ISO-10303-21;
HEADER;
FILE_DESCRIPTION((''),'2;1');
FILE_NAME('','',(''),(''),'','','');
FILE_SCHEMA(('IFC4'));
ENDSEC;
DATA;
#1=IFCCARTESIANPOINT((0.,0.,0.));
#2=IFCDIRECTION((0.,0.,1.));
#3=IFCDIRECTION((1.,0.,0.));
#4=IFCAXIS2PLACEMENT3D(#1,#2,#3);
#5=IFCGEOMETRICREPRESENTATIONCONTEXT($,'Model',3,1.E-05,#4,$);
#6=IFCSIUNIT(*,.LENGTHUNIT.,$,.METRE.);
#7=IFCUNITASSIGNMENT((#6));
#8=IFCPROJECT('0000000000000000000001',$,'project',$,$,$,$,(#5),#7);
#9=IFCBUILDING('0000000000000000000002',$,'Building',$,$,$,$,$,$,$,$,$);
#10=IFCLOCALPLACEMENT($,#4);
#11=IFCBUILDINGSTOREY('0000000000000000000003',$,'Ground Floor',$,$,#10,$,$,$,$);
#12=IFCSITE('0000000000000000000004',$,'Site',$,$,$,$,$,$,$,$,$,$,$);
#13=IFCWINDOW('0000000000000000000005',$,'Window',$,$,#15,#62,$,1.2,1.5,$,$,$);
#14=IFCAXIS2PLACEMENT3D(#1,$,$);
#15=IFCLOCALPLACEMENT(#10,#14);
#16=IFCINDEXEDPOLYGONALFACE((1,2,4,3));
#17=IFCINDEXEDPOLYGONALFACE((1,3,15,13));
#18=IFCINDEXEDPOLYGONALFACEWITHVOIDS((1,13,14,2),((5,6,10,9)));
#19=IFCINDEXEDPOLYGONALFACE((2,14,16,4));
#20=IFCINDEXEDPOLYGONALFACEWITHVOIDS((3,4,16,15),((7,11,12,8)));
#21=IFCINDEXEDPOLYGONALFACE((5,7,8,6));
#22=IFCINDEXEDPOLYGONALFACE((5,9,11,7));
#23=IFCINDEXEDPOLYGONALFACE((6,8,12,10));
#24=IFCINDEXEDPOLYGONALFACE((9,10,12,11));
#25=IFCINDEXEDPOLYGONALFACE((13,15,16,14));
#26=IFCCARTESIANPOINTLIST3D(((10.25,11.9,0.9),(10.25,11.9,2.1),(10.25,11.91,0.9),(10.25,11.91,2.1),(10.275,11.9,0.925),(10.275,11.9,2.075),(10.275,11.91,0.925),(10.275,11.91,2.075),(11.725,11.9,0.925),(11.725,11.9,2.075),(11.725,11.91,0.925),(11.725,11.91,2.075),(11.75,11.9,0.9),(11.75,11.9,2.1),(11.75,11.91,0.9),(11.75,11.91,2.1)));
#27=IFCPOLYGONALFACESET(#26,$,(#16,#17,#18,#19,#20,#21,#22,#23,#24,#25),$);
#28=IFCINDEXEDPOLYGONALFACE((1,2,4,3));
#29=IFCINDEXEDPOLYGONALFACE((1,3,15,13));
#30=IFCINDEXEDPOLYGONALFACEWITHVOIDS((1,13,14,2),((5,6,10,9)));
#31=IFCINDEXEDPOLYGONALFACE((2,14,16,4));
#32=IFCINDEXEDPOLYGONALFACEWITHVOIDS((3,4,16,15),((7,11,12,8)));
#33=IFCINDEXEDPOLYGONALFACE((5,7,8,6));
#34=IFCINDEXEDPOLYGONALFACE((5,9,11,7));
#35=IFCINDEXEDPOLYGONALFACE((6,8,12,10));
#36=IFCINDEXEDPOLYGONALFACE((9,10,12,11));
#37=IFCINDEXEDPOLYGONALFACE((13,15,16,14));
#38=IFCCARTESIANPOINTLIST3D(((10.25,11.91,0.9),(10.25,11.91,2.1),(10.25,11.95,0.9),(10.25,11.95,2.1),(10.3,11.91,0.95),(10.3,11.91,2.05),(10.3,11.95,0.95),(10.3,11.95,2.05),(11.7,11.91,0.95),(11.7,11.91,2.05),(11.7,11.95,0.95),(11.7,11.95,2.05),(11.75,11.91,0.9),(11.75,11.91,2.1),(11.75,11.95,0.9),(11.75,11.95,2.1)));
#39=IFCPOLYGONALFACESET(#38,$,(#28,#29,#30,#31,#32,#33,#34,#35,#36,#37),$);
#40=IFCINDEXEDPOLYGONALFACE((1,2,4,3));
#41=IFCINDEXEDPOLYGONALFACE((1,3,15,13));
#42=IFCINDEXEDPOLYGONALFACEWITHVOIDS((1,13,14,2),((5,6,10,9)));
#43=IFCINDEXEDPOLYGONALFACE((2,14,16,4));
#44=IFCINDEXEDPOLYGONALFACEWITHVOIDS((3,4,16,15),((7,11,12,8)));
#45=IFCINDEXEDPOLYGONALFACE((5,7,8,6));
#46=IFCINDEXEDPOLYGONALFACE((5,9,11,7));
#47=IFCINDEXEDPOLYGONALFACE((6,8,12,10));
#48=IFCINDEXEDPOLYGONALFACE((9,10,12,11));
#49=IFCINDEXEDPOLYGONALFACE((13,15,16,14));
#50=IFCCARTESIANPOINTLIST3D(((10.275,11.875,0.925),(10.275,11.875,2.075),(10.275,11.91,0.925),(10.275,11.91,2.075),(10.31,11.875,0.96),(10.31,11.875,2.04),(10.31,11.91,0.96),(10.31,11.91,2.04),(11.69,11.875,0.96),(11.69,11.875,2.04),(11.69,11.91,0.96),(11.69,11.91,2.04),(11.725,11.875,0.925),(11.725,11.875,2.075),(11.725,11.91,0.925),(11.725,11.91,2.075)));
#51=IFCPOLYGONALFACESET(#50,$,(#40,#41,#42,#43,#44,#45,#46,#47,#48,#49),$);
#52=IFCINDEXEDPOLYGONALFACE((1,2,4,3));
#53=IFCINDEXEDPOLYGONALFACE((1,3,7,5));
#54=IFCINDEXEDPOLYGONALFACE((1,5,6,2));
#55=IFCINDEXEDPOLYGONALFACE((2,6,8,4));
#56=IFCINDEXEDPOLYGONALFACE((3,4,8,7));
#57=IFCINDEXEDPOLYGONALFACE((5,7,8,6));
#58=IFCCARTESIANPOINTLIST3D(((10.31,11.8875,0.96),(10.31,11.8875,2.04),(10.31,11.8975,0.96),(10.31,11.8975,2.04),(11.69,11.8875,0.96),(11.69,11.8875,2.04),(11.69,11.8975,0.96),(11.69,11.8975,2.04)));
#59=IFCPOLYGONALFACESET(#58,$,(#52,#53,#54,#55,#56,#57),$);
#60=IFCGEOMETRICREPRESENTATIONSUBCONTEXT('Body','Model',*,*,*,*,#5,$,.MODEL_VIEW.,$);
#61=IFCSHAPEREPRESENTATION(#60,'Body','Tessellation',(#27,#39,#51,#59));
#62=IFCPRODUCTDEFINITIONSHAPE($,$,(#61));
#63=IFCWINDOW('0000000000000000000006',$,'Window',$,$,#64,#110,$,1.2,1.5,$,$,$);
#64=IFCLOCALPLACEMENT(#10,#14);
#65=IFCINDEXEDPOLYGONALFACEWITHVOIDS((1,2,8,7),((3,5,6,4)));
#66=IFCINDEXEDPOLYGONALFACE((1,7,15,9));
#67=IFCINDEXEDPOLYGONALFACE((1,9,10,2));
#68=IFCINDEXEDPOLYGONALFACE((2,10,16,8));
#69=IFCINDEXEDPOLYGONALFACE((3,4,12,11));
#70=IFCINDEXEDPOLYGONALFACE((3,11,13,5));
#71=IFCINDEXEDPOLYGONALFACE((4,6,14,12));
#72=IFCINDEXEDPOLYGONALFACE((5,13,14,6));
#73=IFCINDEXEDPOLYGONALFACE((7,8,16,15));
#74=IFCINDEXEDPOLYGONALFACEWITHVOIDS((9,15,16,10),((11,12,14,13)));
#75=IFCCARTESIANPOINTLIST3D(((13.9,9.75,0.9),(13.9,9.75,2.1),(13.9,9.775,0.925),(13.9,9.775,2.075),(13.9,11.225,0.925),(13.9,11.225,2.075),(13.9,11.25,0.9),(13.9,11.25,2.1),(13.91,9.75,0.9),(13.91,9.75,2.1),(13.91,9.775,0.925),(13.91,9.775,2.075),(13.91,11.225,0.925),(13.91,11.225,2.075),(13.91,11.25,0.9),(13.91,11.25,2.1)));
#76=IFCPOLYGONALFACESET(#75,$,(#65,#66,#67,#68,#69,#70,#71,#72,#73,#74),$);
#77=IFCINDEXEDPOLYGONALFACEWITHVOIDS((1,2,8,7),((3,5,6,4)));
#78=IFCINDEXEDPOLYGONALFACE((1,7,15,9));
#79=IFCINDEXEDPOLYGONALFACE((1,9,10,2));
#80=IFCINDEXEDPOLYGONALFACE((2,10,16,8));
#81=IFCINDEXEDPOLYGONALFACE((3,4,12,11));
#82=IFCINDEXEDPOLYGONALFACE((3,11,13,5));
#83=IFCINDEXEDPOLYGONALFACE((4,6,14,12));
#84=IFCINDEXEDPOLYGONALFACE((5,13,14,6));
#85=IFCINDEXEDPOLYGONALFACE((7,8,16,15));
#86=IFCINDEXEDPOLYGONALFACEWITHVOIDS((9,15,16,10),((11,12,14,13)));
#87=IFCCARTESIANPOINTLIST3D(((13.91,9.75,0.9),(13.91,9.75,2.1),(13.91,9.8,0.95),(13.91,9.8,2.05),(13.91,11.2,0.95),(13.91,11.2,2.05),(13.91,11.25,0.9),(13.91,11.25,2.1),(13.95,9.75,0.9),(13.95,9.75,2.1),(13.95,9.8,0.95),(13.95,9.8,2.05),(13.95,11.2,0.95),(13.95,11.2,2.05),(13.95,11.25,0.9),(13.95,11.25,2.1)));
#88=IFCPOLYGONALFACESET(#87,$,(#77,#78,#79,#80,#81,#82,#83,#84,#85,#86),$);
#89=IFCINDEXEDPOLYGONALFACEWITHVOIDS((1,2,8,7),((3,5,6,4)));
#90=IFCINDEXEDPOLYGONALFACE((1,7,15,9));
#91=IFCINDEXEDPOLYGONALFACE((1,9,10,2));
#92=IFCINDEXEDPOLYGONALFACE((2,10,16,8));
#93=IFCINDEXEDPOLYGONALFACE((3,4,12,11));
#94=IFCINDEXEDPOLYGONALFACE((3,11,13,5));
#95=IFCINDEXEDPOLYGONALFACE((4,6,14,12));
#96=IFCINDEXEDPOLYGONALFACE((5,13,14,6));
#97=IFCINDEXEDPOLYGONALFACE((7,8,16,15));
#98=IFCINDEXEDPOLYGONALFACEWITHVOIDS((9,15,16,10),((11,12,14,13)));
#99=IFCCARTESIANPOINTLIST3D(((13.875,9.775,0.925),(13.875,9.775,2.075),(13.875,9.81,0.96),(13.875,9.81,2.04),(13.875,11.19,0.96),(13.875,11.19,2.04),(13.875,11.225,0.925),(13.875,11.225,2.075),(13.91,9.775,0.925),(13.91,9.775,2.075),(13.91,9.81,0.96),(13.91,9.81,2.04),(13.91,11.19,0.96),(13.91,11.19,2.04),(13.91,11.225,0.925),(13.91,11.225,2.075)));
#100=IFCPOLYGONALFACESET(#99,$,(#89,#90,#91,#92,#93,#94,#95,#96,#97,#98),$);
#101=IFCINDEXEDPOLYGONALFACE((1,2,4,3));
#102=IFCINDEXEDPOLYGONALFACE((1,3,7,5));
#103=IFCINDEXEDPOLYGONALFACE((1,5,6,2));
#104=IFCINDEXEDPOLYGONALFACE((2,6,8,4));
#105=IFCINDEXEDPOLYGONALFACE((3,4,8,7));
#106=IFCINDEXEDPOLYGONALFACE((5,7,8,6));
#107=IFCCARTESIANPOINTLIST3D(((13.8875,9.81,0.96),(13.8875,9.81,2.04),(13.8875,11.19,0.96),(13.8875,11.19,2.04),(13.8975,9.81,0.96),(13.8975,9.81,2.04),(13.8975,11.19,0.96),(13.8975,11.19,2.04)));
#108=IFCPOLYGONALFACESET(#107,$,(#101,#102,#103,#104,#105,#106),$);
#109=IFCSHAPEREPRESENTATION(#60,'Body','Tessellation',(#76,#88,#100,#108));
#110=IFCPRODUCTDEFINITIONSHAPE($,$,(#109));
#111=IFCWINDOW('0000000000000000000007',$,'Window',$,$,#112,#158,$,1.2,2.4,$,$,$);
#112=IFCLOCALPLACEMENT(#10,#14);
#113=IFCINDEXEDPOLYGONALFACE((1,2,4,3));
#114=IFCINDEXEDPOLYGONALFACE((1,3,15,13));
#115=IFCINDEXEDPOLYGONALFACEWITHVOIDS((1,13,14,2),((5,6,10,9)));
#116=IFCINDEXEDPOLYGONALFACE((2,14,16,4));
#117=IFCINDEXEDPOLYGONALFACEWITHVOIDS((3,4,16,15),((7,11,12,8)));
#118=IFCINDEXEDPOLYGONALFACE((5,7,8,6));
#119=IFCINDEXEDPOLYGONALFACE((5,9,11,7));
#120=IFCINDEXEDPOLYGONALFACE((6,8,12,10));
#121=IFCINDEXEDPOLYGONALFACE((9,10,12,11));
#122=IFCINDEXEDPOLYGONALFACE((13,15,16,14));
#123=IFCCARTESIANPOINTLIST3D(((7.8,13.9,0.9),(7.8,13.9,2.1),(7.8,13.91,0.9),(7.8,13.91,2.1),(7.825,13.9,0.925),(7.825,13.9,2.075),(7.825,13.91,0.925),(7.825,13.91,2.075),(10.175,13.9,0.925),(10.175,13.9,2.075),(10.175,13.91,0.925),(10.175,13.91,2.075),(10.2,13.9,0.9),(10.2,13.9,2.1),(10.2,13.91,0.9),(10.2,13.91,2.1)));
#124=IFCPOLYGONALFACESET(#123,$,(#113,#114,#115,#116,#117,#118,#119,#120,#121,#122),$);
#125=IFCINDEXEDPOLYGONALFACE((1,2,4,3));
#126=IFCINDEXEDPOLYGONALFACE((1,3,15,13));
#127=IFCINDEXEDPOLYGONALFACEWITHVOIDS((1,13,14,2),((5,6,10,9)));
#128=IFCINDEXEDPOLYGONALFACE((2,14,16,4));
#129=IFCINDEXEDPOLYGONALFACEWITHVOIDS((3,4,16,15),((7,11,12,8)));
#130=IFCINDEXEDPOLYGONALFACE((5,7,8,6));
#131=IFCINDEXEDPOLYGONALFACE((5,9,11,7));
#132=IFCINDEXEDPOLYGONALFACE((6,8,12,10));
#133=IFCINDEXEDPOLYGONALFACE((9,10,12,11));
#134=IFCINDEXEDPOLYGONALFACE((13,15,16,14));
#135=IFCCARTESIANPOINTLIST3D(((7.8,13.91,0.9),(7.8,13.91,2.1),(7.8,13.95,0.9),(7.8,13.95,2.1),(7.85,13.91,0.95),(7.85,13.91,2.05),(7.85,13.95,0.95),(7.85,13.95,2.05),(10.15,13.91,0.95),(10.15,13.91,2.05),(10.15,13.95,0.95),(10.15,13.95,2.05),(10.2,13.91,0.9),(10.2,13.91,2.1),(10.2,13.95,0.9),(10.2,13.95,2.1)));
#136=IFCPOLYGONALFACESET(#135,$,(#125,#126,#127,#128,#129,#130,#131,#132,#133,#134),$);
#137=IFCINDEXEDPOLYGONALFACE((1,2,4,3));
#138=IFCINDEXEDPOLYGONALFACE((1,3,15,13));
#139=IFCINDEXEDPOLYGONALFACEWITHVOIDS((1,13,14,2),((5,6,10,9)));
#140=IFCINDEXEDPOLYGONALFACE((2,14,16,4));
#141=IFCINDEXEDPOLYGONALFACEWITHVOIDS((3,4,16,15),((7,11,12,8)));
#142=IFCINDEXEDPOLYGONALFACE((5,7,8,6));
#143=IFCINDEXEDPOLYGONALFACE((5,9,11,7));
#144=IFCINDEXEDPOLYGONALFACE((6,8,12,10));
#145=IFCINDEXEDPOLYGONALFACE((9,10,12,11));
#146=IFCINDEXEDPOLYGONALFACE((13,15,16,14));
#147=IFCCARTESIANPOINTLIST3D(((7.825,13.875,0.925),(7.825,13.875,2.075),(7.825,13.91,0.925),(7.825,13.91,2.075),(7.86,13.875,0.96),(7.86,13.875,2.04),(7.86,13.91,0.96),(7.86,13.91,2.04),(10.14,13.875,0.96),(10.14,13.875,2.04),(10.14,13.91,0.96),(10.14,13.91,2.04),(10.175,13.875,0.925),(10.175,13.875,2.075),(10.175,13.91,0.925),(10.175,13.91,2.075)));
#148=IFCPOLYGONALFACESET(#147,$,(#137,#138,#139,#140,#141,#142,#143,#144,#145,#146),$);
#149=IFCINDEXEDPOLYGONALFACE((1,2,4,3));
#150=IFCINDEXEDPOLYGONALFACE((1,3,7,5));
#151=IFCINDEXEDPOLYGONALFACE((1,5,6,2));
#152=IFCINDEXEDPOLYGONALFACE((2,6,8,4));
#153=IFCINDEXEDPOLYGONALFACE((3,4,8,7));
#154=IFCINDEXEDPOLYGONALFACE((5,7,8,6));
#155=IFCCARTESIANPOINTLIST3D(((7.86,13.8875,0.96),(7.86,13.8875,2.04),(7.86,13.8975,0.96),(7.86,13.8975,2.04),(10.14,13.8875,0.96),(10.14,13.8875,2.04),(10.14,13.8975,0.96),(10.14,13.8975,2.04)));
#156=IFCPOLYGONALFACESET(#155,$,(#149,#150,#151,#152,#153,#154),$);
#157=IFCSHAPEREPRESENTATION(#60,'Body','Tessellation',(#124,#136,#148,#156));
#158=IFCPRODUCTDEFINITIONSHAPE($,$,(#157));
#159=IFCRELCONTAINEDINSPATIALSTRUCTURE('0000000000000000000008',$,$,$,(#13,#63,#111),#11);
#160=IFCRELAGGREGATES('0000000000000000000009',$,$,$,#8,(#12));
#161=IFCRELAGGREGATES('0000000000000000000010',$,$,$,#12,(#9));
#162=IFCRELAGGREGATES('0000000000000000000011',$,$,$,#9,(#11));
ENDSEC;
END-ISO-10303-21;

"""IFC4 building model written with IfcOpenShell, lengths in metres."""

from ifc_helpers import new_model, si_unit, frame, origin_with_axes, place, context, subcontext, project, spatial, line, indexed_curve, outline, extrude, element, save


model = new_model("IFC4")

# Units and contexts
model_context = context("Model", 3, precision=1e-05, world=origin_with_axes())
body_context = subcontext(model_context, "Body", "Model", "MODEL_VIEW")
ifc_project = project(units=[si_unit("LENGTHUNIT", "METRE")], contexts=[model_context])

# Site, building, storey
site = spatial("IfcSite", under=ifc_project, Name="Site")
building = spatial("IfcBuilding", under=site, Name="Building")
storey_placement = place(None, origin_with_axes())
storey = spatial("IfcBuildingStorey", under=building, at=storey_placement, Name="Ground Floor")

# Windows
for number, where, z_axis, x_axis, name in (
    (1, (11.75, 12.0, 0.9), (0.0, 0.0, 1.0), (-1.0, 0.0, 0.0), "Window"),
    (2, (14.0, 9.75, 0.9), (0.0, 0.0, 1.0), (0.0, 1.0, 0.0), "Window"),
):
    element("IfcWindow", number, at=place(storey_placement, frame(where, z_axis=z_axis, x_axis=x_axis)), inside=storey, Name=name, OverallHeight=1.2, OverallWidth=1.5, context=body_context, shape_type="SweptSolid", body=[
        extrude(outline(indexed_curve([(0.0, 0.0), (1.5, 0.0), (1.5, 1.2), (0.0, 1.2)], segments=[line(1, 2, 3, 4, 1)]), holes=[indexed_curve([(0.025, 0.025), (1.475, 0.025), (1.475, 1.175), (0.025, 1.175)], segments=[line(1, 2, 3, 4, 1)])]), frame((0.0, 0.09, 0.0), z_axis=(0.0, -1.0, 0.0), x_axis=(1.0, 0.0, 0.0)), (0.0, 0.0, -1.0), 0.01),
        extrude(outline(indexed_curve([(0.0, 0.0), (1.5, 0.0), (1.5, 1.2), (0.0, 1.2)], segments=[line(1, 2, 3, 4, 1)]), holes=[indexed_curve([(0.05, 0.05), (1.45, 0.05), (1.45, 1.15), (0.05, 1.15)], segments=[line(1, 2, 3, 4, 1)])]), frame((0.0, 0.05, 0.0), z_axis=(0.0, -1.0, 0.0), x_axis=(1.0, 0.0, 0.0)), (0.0, 0.0, -1.0), 0.04),
        extrude(outline(indexed_curve([(0.0, 0.0), (1.45, 0.0), (1.45, 1.15), (0.0, 1.15)], segments=[line(1, 2, 3, 4, 1)]), holes=[indexed_curve([(0.035, 0.035), (1.415, 0.035), (1.415, 1.115), (0.035, 1.115)], segments=[line(1, 2, 3, 4, 1)])]), frame((0.025, 0.09, 0.025), z_axis=(0.0, -1.0, 0.0), x_axis=(1.0, 0.0, 0.0)), (0.0, 0.0, -1.0), 0.035),
        extrude(outline(indexed_curve([(0.035, 0.035), (1.415, 0.035), (1.415, 1.115), (0.035, 1.115)], segments=[line(1, 2, 3, 4, 1)])), frame((0.025, 0.1025, 0.025), z_axis=(0.0, -1.0, 0.0), x_axis=(1.0, 0.0, 0.0)), (0.0, 0.0, -1.0), 0.01),
    ])
window_1_placement = place(storey_placement, frame((10.2, 14.0, 0.9), z_axis=(0.0, 0.0, 1.0), x_axis=(-1.0, 0.0, 0.0)))
element("IfcWindow", 3, at=window_1_placement, inside=storey, Name="Window", OverallHeight=1.2, OverallWidth=2.4, context=body_context, shape_type="SweptSolid", body=[
    extrude(outline(indexed_curve([(0.0, 0.0), (2.4, 0.0), (2.4, 1.2), (0.0, 1.2)], segments=[line(1, 2, 3, 4, 1)]), holes=[indexed_curve([(0.025, 0.025), (2.375, 0.025), (2.375, 1.175), (0.025, 1.175)], segments=[line(1, 2, 3, 4, 1)])]), frame((0.0, 0.09, 0.0), z_axis=(0.0, -1.0, 0.0), x_axis=(1.0, 0.0, 0.0)), (0.0, 0.0, -1.0), 0.01),
    extrude(outline(indexed_curve([(0.0, 0.0), (2.4, 0.0), (2.4, 1.2), (0.0, 1.2)], segments=[line(1, 2, 3, 4, 1)]), holes=[indexed_curve([(0.05, 0.05), (2.35, 0.05), (2.35, 1.15), (0.05, 1.15)], segments=[line(1, 2, 3, 4, 1)])]), frame((0.0, 0.05, 0.0), z_axis=(0.0, -1.0, 0.0), x_axis=(1.0, 0.0, 0.0)), (0.0, 0.0, -1.0), 0.04),
    extrude(outline(indexed_curve([(0.0, 0.0), (2.35, 0.0), (2.35, 1.15), (0.0, 1.15)], segments=[line(1, 2, 3, 4, 1)]), holes=[indexed_curve([(0.035, 0.035), (2.315, 0.035), (2.315, 1.115), (0.035, 1.115)], segments=[line(1, 2, 3, 4, 1)])]), frame((0.025, 0.09, 0.025), z_axis=(0.0, -1.0, 0.0), x_axis=(1.0, 0.0, 0.0)), (0.0, 0.0, -1.0), 0.035),
    extrude(outline(indexed_curve([(0.035, 0.035), (2.315, 0.035), (2.315, 1.115), (0.035, 1.115)], segments=[line(1, 2, 3, 4, 1)])), frame((0.025, 0.1025, 0.025), z_axis=(0.0, -1.0, 0.0), x_axis=(1.0, 0.0, 0.0)), (0.0, 0.0, -1.0), 0.01),
])

save(model, "model.ifc")
